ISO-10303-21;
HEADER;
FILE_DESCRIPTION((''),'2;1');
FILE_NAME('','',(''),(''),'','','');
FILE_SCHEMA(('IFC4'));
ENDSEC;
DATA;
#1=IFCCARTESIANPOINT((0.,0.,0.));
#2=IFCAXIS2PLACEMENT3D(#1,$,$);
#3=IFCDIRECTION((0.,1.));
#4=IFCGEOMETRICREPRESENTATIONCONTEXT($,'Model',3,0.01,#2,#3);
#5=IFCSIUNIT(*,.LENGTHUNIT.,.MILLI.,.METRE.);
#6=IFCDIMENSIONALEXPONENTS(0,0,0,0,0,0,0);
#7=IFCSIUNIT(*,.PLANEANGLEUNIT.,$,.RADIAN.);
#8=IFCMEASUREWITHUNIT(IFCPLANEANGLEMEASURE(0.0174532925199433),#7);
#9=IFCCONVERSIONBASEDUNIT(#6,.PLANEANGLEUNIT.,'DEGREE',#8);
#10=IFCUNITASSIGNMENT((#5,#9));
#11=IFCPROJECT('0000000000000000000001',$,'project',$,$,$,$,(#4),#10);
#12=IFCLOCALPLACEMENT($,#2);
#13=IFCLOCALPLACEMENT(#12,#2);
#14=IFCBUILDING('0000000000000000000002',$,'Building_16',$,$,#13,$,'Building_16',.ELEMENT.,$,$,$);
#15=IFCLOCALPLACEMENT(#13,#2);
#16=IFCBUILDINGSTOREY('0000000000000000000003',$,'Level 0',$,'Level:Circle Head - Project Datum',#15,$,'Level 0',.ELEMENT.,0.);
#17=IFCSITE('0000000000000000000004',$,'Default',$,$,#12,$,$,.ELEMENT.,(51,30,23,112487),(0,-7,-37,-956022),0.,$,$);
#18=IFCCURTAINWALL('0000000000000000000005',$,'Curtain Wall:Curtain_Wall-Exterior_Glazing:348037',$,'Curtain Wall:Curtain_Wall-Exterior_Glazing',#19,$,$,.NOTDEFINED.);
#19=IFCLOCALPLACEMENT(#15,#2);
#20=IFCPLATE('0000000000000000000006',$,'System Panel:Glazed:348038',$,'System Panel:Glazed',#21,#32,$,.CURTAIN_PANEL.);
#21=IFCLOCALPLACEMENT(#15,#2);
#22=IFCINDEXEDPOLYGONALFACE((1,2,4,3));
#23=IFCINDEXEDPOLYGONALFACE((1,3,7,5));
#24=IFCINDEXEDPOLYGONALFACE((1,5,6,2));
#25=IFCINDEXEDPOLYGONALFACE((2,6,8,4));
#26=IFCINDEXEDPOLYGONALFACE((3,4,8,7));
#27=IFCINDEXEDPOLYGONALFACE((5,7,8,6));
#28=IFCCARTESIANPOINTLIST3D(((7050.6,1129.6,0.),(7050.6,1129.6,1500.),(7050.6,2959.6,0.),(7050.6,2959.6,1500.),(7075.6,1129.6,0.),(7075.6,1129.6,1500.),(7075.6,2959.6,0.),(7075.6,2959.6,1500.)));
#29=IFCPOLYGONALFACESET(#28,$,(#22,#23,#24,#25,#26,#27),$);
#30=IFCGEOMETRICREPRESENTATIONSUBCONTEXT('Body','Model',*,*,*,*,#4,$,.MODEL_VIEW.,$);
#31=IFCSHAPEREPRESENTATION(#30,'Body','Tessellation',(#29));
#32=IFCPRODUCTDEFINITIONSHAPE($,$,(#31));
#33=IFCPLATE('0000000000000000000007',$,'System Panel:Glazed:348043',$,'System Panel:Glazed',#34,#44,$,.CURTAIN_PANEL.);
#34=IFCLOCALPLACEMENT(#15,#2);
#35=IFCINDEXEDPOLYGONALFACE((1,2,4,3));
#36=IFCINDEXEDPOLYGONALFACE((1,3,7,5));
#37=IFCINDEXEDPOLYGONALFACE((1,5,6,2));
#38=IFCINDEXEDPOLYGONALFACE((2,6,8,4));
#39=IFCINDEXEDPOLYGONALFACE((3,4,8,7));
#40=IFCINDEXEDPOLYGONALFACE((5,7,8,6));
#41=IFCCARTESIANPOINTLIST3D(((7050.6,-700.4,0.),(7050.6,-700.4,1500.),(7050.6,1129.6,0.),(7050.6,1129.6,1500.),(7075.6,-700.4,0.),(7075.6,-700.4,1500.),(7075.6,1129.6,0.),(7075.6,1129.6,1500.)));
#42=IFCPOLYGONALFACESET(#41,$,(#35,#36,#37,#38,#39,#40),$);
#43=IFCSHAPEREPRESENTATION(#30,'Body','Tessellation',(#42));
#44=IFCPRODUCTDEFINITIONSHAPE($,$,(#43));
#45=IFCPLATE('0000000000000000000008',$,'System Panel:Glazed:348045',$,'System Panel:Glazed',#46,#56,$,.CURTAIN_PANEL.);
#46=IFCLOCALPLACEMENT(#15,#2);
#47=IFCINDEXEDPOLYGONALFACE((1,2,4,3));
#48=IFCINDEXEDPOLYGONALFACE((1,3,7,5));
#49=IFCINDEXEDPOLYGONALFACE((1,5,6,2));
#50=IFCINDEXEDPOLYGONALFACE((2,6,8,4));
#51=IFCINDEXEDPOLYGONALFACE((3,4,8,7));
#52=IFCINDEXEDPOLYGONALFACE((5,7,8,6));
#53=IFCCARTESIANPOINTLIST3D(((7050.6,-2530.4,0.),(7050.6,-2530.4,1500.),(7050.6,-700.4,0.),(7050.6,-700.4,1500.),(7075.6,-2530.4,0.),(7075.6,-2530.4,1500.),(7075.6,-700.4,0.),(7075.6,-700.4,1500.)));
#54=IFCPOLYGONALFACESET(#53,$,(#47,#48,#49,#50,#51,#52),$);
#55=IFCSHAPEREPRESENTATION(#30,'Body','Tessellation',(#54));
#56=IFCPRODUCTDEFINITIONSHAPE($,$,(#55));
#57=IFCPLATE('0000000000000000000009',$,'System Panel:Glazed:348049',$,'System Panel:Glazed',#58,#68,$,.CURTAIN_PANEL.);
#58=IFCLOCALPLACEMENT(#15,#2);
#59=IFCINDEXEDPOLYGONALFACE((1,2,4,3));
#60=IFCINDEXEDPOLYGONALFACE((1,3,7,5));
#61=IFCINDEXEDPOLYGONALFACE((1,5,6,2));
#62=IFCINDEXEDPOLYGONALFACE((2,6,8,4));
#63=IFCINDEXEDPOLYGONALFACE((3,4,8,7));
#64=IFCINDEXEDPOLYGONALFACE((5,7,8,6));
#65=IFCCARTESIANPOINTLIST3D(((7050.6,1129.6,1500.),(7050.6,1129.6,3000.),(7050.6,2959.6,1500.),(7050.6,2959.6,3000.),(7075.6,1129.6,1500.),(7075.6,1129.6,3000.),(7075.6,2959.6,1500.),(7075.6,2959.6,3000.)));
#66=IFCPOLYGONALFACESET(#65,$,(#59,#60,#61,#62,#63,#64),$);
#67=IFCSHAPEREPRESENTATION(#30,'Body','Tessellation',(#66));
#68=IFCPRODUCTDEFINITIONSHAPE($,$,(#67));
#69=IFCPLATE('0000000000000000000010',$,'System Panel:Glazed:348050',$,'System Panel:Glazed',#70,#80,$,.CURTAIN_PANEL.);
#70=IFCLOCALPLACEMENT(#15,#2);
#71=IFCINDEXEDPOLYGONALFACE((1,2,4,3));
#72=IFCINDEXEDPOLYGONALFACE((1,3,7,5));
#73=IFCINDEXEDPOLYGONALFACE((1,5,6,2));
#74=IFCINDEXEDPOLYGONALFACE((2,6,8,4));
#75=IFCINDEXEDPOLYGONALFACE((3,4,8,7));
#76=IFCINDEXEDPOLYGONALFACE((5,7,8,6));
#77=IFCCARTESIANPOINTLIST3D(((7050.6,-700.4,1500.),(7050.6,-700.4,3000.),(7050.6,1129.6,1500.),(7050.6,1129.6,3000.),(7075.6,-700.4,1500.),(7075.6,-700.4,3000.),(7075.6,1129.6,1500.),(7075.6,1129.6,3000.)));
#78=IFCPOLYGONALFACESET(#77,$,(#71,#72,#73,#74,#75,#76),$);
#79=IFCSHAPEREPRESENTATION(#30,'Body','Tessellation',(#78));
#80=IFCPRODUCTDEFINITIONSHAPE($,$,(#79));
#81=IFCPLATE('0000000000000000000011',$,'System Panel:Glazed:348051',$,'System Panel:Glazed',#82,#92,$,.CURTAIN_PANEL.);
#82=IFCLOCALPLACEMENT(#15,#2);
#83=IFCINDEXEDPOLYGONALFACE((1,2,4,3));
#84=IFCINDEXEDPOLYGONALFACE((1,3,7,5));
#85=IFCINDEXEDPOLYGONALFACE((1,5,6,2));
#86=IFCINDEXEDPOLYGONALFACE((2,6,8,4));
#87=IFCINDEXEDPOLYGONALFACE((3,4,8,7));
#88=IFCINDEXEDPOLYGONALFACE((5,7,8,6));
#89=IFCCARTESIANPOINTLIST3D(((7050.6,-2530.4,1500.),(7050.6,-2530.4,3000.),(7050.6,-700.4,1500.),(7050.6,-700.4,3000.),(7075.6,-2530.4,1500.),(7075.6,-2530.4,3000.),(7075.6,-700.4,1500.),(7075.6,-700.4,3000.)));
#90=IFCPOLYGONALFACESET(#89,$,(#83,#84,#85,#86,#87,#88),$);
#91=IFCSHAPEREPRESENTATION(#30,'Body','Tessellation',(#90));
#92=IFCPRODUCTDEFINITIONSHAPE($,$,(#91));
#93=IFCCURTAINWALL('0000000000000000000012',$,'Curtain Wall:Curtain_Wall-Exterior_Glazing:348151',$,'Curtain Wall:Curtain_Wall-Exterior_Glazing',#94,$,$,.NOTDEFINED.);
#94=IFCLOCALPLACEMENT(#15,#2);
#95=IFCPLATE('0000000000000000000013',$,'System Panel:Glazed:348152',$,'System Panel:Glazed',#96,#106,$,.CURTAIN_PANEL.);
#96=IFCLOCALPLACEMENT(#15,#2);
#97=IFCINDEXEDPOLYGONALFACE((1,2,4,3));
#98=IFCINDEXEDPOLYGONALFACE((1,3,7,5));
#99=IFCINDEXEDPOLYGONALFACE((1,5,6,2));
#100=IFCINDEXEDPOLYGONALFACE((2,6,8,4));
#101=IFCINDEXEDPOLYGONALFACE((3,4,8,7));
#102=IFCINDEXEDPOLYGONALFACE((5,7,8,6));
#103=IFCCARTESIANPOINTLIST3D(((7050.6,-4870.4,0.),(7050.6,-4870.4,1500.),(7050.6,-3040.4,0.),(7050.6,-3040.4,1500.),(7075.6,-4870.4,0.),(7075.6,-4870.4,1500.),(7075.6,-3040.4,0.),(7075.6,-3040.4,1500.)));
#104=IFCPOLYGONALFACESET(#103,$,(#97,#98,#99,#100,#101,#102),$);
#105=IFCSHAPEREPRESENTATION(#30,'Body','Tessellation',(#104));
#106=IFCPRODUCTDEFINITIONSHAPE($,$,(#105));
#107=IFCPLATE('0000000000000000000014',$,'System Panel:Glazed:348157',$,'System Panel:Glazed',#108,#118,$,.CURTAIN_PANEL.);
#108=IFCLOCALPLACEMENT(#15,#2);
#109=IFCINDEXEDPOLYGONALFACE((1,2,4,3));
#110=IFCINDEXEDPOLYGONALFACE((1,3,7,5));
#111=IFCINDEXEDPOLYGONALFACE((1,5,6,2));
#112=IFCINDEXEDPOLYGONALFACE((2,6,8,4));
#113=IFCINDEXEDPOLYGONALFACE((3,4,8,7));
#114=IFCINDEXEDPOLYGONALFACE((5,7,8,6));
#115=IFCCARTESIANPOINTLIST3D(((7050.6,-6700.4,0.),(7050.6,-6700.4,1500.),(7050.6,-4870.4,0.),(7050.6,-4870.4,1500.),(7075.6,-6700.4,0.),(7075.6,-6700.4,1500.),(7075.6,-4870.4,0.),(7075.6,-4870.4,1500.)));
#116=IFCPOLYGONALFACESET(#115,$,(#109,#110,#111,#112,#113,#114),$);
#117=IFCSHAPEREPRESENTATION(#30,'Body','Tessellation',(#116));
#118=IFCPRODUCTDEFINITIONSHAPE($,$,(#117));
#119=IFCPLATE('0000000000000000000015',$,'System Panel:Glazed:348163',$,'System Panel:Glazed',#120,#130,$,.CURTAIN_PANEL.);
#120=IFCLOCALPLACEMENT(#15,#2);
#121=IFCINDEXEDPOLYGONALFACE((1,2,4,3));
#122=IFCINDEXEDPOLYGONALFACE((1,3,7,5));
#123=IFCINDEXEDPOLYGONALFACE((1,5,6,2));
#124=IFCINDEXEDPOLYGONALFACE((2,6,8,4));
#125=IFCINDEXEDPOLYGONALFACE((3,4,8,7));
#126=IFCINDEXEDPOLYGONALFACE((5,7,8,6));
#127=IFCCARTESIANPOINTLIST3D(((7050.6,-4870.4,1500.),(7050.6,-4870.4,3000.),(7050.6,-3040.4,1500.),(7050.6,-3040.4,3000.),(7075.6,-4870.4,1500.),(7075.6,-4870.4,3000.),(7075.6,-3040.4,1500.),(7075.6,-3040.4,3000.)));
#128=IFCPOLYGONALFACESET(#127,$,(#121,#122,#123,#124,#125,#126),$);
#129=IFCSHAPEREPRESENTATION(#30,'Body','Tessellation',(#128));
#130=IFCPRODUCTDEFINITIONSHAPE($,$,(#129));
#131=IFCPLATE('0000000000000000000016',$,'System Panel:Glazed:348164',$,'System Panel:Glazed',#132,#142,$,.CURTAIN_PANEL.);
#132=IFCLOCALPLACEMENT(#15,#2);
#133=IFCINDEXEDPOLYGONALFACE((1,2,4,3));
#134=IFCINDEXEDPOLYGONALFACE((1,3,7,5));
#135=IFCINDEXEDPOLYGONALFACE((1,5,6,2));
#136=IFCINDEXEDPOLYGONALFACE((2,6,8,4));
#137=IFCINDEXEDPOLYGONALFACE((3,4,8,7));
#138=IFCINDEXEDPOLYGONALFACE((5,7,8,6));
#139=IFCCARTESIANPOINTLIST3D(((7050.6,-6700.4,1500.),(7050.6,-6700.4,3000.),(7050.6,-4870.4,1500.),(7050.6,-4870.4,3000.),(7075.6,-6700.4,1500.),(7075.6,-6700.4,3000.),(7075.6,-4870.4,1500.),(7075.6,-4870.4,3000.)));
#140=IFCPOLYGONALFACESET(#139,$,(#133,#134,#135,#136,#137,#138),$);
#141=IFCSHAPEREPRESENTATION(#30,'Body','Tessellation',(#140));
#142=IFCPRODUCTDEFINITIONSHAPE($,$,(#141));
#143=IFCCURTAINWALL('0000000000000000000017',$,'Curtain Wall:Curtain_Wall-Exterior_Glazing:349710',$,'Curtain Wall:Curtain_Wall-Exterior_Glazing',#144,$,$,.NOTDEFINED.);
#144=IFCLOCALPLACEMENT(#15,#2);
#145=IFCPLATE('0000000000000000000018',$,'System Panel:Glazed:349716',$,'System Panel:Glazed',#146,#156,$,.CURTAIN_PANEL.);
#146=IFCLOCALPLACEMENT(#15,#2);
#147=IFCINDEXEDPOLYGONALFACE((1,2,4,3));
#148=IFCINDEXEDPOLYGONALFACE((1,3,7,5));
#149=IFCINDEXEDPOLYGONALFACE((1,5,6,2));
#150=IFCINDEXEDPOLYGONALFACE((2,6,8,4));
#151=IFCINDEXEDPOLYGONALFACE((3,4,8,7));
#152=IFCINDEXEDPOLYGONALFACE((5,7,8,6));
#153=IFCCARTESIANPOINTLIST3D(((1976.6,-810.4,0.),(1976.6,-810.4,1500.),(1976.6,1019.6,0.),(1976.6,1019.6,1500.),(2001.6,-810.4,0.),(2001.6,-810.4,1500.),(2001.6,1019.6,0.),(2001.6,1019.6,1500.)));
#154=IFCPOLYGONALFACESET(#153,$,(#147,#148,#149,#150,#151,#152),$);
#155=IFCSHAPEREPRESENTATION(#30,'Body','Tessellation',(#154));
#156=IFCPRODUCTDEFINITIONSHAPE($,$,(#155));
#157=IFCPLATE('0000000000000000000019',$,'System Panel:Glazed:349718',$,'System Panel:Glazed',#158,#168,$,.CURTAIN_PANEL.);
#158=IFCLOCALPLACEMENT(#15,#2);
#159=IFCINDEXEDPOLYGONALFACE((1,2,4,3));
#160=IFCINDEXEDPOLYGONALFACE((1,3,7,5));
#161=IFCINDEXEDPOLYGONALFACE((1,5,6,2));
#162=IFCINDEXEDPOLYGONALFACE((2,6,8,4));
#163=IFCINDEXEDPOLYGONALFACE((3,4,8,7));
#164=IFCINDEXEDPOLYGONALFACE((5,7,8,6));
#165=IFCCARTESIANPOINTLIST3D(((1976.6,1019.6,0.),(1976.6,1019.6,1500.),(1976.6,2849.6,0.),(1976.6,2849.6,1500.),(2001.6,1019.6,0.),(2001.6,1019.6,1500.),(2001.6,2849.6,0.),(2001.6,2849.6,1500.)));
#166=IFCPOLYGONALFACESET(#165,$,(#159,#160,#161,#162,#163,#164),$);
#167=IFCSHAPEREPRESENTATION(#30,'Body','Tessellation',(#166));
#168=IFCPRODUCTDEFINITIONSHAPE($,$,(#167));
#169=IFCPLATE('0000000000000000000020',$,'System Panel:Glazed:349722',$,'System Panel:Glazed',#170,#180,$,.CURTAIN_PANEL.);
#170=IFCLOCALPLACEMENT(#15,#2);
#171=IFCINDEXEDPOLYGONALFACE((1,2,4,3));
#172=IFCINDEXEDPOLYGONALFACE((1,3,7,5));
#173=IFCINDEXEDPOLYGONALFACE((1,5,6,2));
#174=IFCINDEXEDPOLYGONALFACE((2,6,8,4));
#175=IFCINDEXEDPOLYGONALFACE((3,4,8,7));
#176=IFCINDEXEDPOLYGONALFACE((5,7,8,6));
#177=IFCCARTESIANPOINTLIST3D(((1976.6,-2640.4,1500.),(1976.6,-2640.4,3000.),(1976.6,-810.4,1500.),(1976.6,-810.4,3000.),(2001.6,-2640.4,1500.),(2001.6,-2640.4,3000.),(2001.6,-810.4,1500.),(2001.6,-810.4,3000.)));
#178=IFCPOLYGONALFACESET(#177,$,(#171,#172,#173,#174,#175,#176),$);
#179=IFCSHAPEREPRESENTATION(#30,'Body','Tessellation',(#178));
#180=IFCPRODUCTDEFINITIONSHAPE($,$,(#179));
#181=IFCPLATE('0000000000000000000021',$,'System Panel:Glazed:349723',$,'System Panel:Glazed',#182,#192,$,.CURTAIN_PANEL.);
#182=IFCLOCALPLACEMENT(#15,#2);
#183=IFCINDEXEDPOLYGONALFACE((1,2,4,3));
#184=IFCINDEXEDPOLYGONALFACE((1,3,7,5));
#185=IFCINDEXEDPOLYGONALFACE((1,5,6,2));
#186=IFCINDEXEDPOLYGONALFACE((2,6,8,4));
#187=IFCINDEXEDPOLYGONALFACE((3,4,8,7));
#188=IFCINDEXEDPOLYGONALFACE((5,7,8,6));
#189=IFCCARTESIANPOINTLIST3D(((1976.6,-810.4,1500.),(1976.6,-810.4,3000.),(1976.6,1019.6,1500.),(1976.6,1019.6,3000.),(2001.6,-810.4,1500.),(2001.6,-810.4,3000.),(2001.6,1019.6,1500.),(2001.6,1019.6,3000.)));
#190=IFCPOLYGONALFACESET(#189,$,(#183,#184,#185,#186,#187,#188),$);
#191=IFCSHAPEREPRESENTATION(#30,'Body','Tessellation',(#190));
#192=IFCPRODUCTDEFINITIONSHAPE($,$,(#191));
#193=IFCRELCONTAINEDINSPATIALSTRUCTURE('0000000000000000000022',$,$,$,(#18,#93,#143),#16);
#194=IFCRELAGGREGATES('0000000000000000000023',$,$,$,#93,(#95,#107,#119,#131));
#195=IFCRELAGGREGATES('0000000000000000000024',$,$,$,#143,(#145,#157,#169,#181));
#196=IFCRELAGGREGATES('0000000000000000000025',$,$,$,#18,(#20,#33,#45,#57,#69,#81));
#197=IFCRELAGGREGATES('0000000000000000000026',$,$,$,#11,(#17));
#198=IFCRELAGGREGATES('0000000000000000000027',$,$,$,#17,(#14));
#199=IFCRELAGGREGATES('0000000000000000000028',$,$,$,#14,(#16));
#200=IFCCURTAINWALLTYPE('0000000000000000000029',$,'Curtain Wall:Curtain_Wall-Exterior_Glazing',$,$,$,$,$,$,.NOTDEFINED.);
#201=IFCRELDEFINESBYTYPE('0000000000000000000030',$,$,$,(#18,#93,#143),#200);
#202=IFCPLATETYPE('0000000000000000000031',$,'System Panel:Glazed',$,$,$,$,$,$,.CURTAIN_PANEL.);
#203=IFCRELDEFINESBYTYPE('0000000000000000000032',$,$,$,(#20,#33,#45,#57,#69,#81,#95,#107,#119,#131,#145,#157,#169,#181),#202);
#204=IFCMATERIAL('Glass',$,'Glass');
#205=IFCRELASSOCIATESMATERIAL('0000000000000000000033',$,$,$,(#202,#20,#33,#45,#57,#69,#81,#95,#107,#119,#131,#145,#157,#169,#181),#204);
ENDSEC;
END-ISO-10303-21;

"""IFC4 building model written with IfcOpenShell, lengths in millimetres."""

from ifc_helpers import new_model, entity, si_unit, converted_unit, direction, frame, origin, place, context, subcontext, project, spatial, indexed_curve, outline, extrude, source, transform, mapped, material, type_object, type_shapes, element, aggregate, save


model = new_model("IFC4")

# Units and contexts
model_context = context("Model", 3, precision=0.01, world=origin(), true_north=direction((0.0, 1.0)))
body_context = subcontext(model_context, "Body", "Model", "MODEL_VIEW")
ifc_project = project(units=[si_unit("LENGTHUNIT", "METRE", prefix="MILLI"), converted_unit("PLANEANGLEUNIT", "DEGREE", entity("IfcPlaneAngleMeasure", 0.0174532925199433), si_unit("PLANEANGLEUNIT", "RADIAN"), dimensions=[0, 0, 0, 0, 0, 0, 0])], contexts=[model_context])

# Site, building, storey
site_placement = place(None, origin())
site = spatial("IfcSite", under=ifc_project, at=site_placement, Name="Default", CompositionType="ELEMENT", RefLatitude=(51, 30, 23, 112487), RefLongitude=(0, -7, -37, -956022), RefElevation=0.0)
building_placement = place(site_placement, origin())
building = spatial("IfcBuilding", under=site, at=building_placement, Name="Building_16", LongName="Building_16", CompositionType="ELEMENT")
storey_placement = place(building_placement, origin())
storey = spatial("IfcBuildingStorey", under=building, at=storey_placement, Name="Level 0", ObjectType="Level:Circle Head - Project Datum", LongName="Level 0", CompositionType="ELEMENT", Elevation=0.0)

# Curtain walls, plates
curtain_wall_type = type_object("IfcCurtainWallType", Name="Curtain Wall:Curtain_Wall-Exterior_Glazing", PredefinedType="NOTDEFINED")
curtain_wall_1_placement = place(storey_placement, origin())
curtain_wall_1 = element("IfcCurtainWall", 1, at=curtain_wall_1_placement, inside=storey, type_object=curtain_wall_type, Name="Curtain Wall:Curtain_Wall-Exterior_Glazing:348037", ObjectType="Curtain Wall:Curtain_Wall-Exterior_Glazing", PredefinedType="NOTDEFINED")
ifc_material_1 = material(Name="Glass", Category="Glass")
plate_type_1 = type_object("IfcPlateType", Name="System Panel:Glazed", PredefinedType="CURTAIN_PANEL", material=ifc_material_1)
shared_shape_1 = source(origin(), body_context, "Body", "SweptSolid", [
    extrude(outline(indexed_curve([(-12.5, -915.0), (12.5, -915.0), (12.5, 915.0), (-12.5, 915.0), (-12.5, -915.0)], self_intersect=False)), frame((0.0, 37.0, 0.0), z_axis=(0.0, 0.0, 1.0), x_axis=(0.0, 1.0, 0.0)), (0.0, 0.0, 1.0), 1500.0),
])
type_shapes(plate_type_1, [shared_shape_1])
plate_1_placement = place(curtain_wall_1_placement, frame((7026.1, 2044.6, 0.0), z_axis=(0.0, 0.0, 1.0), x_axis=(0.0, -1.0, 0.0)))
plate_1 = element("IfcPlate", 2, at=plate_1_placement, type_object=plate_type_1, material=ifc_material_1, Name="System Panel:Glazed:348038", ObjectType="System Panel:Glazed", PredefinedType="CURTAIN_PANEL", context=body_context, shape_type="MappedRepresentation", body=[
    mapped(shared_shape_1, transform((0.0, 0.0, 0.0), scale=1.0)),
])
plate_2_placement = place(curtain_wall_1_placement, frame((7026.1, 214.6, 0.0), z_axis=(0.0, 0.0, 1.0), x_axis=(0.0, -1.0, 0.0)))
plate_2 = element("IfcPlate", 3, at=plate_2_placement, type_object=plate_type_1, material=ifc_material_1, Name="System Panel:Glazed:348043", ObjectType="System Panel:Glazed", PredefinedType="CURTAIN_PANEL", context=body_context, shape_type="MappedRepresentation", body=[
    mapped(shared_shape_1, transform((0.0, 0.0, 0.0), scale=1.0)),
])
plate_3_placement = place(curtain_wall_1_placement, frame((7026.1, -1615.4, 0.0), z_axis=(0.0, 0.0, 1.0), x_axis=(0.0, -1.0, 0.0)))
plate_3 = element("IfcPlate", 4, at=plate_3_placement, type_object=plate_type_1, material=ifc_material_1, Name="System Panel:Glazed:348045", ObjectType="System Panel:Glazed", PredefinedType="CURTAIN_PANEL", context=body_context, shape_type="MappedRepresentation", body=[
    mapped(shared_shape_1, transform((0.0, 0.0, 0.0), scale=1.0)),
])
plate_4_placement = place(curtain_wall_1_placement, frame((7026.1, 2044.6, 1500.0), z_axis=(0.0, 0.0, 1.0), x_axis=(0.0, -1.0, 0.0)))
plate_4 = element("IfcPlate", 5, at=plate_4_placement, type_object=plate_type_1, material=ifc_material_1, Name="System Panel:Glazed:348049", ObjectType="System Panel:Glazed", PredefinedType="CURTAIN_PANEL", context=body_context, shape_type="MappedRepresentation", body=[
    mapped(shared_shape_1, transform((0.0, 0.0, 0.0), scale=1.0)),
])
plate_5_placement = place(curtain_wall_1_placement, frame((7026.1, 214.6, 1500.0), z_axis=(0.0, 0.0, 1.0), x_axis=(0.0, -1.0, 0.0)))
plate_5 = element("IfcPlate", 6, at=plate_5_placement, type_object=plate_type_1, material=ifc_material_1, Name="System Panel:Glazed:348050", ObjectType="System Panel:Glazed", PredefinedType="CURTAIN_PANEL", context=body_context, shape_type="MappedRepresentation", body=[
    mapped(shared_shape_1, transform((0.0, 0.0, 0.0), scale=1.0)),
])
plate_6_placement = place(curtain_wall_1_placement, frame((7026.1, -1615.4, 1500.0), z_axis=(0.0, 0.0, 1.0), x_axis=(0.0, -1.0, 0.0)))
plate_6 = element("IfcPlate", 7, at=plate_6_placement, type_object=plate_type_1, material=ifc_material_1, Name="System Panel:Glazed:348051", ObjectType="System Panel:Glazed", PredefinedType="CURTAIN_PANEL", context=body_context, shape_type="MappedRepresentation", body=[
    mapped(shared_shape_1, transform((0.0, 0.0, 0.0), scale=1.0)),
])
curtain_wall_2_placement = place(storey_placement, origin())
curtain_wall_2 = element("IfcCurtainWall", 8, at=curtain_wall_2_placement, inside=storey, type_object=curtain_wall_type, Name="Curtain Wall:Curtain_Wall-Exterior_Glazing:348151", ObjectType="Curtain Wall:Curtain_Wall-Exterior_Glazing", PredefinedType="NOTDEFINED")
plate_7_placement = place(curtain_wall_2_placement, frame((7026.1, -3955.4, 0.0), z_axis=(0.0, 0.0, 1.0), x_axis=(0.0, -1.0, 0.0)))
plate_7 = element("IfcPlate", 9, at=plate_7_placement, type_object=plate_type_1, material=ifc_material_1, Name="System Panel:Glazed:348152", ObjectType="System Panel:Glazed", PredefinedType="CURTAIN_PANEL", context=body_context, shape_type="MappedRepresentation", body=[
    mapped(shared_shape_1, transform((0.0, 0.0, 0.0), scale=1.0)),
])
plate_8_placement = place(curtain_wall_2_placement, frame((7026.1, -5785.4, 0.0), z_axis=(0.0, 0.0, 1.0), x_axis=(0.0, -1.0, 0.0)))
plate_8 = element("IfcPlate", 10, at=plate_8_placement, type_object=plate_type_1, material=ifc_material_1, Name="System Panel:Glazed:348157", ObjectType="System Panel:Glazed", PredefinedType="CURTAIN_PANEL", context=body_context, shape_type="MappedRepresentation", body=[
    mapped(shared_shape_1, transform((0.0, 0.0, 0.0), scale=1.0)),
])
plate_9_placement = place(curtain_wall_2_placement, frame((7026.1, -3955.4, 1500.0), z_axis=(0.0, 0.0, 1.0), x_axis=(0.0, -1.0, 0.0)))
plate_9 = element("IfcPlate", 11, at=plate_9_placement, type_object=plate_type_1, material=ifc_material_1, Name="System Panel:Glazed:348163", ObjectType="System Panel:Glazed", PredefinedType="CURTAIN_PANEL", context=body_context, shape_type="MappedRepresentation", body=[
    mapped(shared_shape_1, transform((0.0, 0.0, 0.0), scale=1.0)),
])
plate_10_placement = place(curtain_wall_2_placement, frame((7026.1, -5785.4, 1500.0), z_axis=(0.0, 0.0, 1.0), x_axis=(0.0, -1.0, 0.0)))
plate_10 = element("IfcPlate", 12, at=plate_10_placement, type_object=plate_type_1, material=ifc_material_1, Name="System Panel:Glazed:348164", ObjectType="System Panel:Glazed", PredefinedType="CURTAIN_PANEL", context=body_context, shape_type="MappedRepresentation", body=[
    mapped(shared_shape_1, transform((0.0, 0.0, 0.0), scale=1.0)),
])
curtain_wall_3_placement = place(storey_placement, origin())
curtain_wall_3 = element("IfcCurtainWall", 13, at=curtain_wall_3_placement, inside=storey, type_object=curtain_wall_type, Name="Curtain Wall:Curtain_Wall-Exterior_Glazing:349710", ObjectType="Curtain Wall:Curtain_Wall-Exterior_Glazing", PredefinedType="NOTDEFINED")
plate_11_placement = place(curtain_wall_3_placement, frame((2026.1, 104.6, 0.0), z_axis=(0.0, 0.0, 1.0), x_axis=(0.0, 1.0, 0.0)))
plate_11 = element("IfcPlate", 14, at=plate_11_placement, type_object=plate_type_1, material=ifc_material_1, Name="System Panel:Glazed:349716", ObjectType="System Panel:Glazed", PredefinedType="CURTAIN_PANEL", context=body_context, shape_type="MappedRepresentation", body=[
    mapped(shared_shape_1, transform((0.0, 0.0, 0.0), scale=1.0)),
])
plate_12_placement = place(curtain_wall_3_placement, frame((2026.1, 1934.6, 0.0), z_axis=(0.0, 0.0, 1.0), x_axis=(0.0, 1.0, 0.0)))
plate_12 = element("IfcPlate", 15, at=plate_12_placement, type_object=plate_type_1, material=ifc_material_1, Name="System Panel:Glazed:349718", ObjectType="System Panel:Glazed", PredefinedType="CURTAIN_PANEL", context=body_context, shape_type="MappedRepresentation", body=[
    mapped(shared_shape_1, transform((0.0, 0.0, 0.0), scale=1.0)),
])
plate_13_placement = place(curtain_wall_3_placement, frame((2026.1, -1725.4, 1500.0), z_axis=(0.0, 0.0, 1.0), x_axis=(0.0, 1.0, 0.0)))
plate_13 = element("IfcPlate", 16, at=plate_13_placement, type_object=plate_type_1, material=ifc_material_1, Name="System Panel:Glazed:349722", ObjectType="System Panel:Glazed", PredefinedType="CURTAIN_PANEL", context=body_context, shape_type="MappedRepresentation", body=[
    mapped(shared_shape_1, transform((0.0, 0.0, 0.0), scale=1.0)),
])
plate_14_placement = place(curtain_wall_3_placement, frame((2026.1, 104.6, 1500.0), z_axis=(0.0, 0.0, 1.0), x_axis=(0.0, 1.0, 0.0)))
plate_14 = element("IfcPlate", 17, at=plate_14_placement, type_object=plate_type_1, material=ifc_material_1, Name="System Panel:Glazed:349723", ObjectType="System Panel:Glazed", PredefinedType="CURTAIN_PANEL", context=body_context, shape_type="MappedRepresentation", body=[
    mapped(shared_shape_1, transform((0.0, 0.0, 0.0), scale=1.0)),
])

aggregate(curtain_wall_2, [plate_7, plate_8, plate_9, plate_10])
aggregate(curtain_wall_3, [plate_11, plate_12, plate_13, plate_14])
aggregate(curtain_wall_1, [plate_1, plate_2, plate_3, plate_4, plate_5, plate_6])

save(model, "model.ifc")
